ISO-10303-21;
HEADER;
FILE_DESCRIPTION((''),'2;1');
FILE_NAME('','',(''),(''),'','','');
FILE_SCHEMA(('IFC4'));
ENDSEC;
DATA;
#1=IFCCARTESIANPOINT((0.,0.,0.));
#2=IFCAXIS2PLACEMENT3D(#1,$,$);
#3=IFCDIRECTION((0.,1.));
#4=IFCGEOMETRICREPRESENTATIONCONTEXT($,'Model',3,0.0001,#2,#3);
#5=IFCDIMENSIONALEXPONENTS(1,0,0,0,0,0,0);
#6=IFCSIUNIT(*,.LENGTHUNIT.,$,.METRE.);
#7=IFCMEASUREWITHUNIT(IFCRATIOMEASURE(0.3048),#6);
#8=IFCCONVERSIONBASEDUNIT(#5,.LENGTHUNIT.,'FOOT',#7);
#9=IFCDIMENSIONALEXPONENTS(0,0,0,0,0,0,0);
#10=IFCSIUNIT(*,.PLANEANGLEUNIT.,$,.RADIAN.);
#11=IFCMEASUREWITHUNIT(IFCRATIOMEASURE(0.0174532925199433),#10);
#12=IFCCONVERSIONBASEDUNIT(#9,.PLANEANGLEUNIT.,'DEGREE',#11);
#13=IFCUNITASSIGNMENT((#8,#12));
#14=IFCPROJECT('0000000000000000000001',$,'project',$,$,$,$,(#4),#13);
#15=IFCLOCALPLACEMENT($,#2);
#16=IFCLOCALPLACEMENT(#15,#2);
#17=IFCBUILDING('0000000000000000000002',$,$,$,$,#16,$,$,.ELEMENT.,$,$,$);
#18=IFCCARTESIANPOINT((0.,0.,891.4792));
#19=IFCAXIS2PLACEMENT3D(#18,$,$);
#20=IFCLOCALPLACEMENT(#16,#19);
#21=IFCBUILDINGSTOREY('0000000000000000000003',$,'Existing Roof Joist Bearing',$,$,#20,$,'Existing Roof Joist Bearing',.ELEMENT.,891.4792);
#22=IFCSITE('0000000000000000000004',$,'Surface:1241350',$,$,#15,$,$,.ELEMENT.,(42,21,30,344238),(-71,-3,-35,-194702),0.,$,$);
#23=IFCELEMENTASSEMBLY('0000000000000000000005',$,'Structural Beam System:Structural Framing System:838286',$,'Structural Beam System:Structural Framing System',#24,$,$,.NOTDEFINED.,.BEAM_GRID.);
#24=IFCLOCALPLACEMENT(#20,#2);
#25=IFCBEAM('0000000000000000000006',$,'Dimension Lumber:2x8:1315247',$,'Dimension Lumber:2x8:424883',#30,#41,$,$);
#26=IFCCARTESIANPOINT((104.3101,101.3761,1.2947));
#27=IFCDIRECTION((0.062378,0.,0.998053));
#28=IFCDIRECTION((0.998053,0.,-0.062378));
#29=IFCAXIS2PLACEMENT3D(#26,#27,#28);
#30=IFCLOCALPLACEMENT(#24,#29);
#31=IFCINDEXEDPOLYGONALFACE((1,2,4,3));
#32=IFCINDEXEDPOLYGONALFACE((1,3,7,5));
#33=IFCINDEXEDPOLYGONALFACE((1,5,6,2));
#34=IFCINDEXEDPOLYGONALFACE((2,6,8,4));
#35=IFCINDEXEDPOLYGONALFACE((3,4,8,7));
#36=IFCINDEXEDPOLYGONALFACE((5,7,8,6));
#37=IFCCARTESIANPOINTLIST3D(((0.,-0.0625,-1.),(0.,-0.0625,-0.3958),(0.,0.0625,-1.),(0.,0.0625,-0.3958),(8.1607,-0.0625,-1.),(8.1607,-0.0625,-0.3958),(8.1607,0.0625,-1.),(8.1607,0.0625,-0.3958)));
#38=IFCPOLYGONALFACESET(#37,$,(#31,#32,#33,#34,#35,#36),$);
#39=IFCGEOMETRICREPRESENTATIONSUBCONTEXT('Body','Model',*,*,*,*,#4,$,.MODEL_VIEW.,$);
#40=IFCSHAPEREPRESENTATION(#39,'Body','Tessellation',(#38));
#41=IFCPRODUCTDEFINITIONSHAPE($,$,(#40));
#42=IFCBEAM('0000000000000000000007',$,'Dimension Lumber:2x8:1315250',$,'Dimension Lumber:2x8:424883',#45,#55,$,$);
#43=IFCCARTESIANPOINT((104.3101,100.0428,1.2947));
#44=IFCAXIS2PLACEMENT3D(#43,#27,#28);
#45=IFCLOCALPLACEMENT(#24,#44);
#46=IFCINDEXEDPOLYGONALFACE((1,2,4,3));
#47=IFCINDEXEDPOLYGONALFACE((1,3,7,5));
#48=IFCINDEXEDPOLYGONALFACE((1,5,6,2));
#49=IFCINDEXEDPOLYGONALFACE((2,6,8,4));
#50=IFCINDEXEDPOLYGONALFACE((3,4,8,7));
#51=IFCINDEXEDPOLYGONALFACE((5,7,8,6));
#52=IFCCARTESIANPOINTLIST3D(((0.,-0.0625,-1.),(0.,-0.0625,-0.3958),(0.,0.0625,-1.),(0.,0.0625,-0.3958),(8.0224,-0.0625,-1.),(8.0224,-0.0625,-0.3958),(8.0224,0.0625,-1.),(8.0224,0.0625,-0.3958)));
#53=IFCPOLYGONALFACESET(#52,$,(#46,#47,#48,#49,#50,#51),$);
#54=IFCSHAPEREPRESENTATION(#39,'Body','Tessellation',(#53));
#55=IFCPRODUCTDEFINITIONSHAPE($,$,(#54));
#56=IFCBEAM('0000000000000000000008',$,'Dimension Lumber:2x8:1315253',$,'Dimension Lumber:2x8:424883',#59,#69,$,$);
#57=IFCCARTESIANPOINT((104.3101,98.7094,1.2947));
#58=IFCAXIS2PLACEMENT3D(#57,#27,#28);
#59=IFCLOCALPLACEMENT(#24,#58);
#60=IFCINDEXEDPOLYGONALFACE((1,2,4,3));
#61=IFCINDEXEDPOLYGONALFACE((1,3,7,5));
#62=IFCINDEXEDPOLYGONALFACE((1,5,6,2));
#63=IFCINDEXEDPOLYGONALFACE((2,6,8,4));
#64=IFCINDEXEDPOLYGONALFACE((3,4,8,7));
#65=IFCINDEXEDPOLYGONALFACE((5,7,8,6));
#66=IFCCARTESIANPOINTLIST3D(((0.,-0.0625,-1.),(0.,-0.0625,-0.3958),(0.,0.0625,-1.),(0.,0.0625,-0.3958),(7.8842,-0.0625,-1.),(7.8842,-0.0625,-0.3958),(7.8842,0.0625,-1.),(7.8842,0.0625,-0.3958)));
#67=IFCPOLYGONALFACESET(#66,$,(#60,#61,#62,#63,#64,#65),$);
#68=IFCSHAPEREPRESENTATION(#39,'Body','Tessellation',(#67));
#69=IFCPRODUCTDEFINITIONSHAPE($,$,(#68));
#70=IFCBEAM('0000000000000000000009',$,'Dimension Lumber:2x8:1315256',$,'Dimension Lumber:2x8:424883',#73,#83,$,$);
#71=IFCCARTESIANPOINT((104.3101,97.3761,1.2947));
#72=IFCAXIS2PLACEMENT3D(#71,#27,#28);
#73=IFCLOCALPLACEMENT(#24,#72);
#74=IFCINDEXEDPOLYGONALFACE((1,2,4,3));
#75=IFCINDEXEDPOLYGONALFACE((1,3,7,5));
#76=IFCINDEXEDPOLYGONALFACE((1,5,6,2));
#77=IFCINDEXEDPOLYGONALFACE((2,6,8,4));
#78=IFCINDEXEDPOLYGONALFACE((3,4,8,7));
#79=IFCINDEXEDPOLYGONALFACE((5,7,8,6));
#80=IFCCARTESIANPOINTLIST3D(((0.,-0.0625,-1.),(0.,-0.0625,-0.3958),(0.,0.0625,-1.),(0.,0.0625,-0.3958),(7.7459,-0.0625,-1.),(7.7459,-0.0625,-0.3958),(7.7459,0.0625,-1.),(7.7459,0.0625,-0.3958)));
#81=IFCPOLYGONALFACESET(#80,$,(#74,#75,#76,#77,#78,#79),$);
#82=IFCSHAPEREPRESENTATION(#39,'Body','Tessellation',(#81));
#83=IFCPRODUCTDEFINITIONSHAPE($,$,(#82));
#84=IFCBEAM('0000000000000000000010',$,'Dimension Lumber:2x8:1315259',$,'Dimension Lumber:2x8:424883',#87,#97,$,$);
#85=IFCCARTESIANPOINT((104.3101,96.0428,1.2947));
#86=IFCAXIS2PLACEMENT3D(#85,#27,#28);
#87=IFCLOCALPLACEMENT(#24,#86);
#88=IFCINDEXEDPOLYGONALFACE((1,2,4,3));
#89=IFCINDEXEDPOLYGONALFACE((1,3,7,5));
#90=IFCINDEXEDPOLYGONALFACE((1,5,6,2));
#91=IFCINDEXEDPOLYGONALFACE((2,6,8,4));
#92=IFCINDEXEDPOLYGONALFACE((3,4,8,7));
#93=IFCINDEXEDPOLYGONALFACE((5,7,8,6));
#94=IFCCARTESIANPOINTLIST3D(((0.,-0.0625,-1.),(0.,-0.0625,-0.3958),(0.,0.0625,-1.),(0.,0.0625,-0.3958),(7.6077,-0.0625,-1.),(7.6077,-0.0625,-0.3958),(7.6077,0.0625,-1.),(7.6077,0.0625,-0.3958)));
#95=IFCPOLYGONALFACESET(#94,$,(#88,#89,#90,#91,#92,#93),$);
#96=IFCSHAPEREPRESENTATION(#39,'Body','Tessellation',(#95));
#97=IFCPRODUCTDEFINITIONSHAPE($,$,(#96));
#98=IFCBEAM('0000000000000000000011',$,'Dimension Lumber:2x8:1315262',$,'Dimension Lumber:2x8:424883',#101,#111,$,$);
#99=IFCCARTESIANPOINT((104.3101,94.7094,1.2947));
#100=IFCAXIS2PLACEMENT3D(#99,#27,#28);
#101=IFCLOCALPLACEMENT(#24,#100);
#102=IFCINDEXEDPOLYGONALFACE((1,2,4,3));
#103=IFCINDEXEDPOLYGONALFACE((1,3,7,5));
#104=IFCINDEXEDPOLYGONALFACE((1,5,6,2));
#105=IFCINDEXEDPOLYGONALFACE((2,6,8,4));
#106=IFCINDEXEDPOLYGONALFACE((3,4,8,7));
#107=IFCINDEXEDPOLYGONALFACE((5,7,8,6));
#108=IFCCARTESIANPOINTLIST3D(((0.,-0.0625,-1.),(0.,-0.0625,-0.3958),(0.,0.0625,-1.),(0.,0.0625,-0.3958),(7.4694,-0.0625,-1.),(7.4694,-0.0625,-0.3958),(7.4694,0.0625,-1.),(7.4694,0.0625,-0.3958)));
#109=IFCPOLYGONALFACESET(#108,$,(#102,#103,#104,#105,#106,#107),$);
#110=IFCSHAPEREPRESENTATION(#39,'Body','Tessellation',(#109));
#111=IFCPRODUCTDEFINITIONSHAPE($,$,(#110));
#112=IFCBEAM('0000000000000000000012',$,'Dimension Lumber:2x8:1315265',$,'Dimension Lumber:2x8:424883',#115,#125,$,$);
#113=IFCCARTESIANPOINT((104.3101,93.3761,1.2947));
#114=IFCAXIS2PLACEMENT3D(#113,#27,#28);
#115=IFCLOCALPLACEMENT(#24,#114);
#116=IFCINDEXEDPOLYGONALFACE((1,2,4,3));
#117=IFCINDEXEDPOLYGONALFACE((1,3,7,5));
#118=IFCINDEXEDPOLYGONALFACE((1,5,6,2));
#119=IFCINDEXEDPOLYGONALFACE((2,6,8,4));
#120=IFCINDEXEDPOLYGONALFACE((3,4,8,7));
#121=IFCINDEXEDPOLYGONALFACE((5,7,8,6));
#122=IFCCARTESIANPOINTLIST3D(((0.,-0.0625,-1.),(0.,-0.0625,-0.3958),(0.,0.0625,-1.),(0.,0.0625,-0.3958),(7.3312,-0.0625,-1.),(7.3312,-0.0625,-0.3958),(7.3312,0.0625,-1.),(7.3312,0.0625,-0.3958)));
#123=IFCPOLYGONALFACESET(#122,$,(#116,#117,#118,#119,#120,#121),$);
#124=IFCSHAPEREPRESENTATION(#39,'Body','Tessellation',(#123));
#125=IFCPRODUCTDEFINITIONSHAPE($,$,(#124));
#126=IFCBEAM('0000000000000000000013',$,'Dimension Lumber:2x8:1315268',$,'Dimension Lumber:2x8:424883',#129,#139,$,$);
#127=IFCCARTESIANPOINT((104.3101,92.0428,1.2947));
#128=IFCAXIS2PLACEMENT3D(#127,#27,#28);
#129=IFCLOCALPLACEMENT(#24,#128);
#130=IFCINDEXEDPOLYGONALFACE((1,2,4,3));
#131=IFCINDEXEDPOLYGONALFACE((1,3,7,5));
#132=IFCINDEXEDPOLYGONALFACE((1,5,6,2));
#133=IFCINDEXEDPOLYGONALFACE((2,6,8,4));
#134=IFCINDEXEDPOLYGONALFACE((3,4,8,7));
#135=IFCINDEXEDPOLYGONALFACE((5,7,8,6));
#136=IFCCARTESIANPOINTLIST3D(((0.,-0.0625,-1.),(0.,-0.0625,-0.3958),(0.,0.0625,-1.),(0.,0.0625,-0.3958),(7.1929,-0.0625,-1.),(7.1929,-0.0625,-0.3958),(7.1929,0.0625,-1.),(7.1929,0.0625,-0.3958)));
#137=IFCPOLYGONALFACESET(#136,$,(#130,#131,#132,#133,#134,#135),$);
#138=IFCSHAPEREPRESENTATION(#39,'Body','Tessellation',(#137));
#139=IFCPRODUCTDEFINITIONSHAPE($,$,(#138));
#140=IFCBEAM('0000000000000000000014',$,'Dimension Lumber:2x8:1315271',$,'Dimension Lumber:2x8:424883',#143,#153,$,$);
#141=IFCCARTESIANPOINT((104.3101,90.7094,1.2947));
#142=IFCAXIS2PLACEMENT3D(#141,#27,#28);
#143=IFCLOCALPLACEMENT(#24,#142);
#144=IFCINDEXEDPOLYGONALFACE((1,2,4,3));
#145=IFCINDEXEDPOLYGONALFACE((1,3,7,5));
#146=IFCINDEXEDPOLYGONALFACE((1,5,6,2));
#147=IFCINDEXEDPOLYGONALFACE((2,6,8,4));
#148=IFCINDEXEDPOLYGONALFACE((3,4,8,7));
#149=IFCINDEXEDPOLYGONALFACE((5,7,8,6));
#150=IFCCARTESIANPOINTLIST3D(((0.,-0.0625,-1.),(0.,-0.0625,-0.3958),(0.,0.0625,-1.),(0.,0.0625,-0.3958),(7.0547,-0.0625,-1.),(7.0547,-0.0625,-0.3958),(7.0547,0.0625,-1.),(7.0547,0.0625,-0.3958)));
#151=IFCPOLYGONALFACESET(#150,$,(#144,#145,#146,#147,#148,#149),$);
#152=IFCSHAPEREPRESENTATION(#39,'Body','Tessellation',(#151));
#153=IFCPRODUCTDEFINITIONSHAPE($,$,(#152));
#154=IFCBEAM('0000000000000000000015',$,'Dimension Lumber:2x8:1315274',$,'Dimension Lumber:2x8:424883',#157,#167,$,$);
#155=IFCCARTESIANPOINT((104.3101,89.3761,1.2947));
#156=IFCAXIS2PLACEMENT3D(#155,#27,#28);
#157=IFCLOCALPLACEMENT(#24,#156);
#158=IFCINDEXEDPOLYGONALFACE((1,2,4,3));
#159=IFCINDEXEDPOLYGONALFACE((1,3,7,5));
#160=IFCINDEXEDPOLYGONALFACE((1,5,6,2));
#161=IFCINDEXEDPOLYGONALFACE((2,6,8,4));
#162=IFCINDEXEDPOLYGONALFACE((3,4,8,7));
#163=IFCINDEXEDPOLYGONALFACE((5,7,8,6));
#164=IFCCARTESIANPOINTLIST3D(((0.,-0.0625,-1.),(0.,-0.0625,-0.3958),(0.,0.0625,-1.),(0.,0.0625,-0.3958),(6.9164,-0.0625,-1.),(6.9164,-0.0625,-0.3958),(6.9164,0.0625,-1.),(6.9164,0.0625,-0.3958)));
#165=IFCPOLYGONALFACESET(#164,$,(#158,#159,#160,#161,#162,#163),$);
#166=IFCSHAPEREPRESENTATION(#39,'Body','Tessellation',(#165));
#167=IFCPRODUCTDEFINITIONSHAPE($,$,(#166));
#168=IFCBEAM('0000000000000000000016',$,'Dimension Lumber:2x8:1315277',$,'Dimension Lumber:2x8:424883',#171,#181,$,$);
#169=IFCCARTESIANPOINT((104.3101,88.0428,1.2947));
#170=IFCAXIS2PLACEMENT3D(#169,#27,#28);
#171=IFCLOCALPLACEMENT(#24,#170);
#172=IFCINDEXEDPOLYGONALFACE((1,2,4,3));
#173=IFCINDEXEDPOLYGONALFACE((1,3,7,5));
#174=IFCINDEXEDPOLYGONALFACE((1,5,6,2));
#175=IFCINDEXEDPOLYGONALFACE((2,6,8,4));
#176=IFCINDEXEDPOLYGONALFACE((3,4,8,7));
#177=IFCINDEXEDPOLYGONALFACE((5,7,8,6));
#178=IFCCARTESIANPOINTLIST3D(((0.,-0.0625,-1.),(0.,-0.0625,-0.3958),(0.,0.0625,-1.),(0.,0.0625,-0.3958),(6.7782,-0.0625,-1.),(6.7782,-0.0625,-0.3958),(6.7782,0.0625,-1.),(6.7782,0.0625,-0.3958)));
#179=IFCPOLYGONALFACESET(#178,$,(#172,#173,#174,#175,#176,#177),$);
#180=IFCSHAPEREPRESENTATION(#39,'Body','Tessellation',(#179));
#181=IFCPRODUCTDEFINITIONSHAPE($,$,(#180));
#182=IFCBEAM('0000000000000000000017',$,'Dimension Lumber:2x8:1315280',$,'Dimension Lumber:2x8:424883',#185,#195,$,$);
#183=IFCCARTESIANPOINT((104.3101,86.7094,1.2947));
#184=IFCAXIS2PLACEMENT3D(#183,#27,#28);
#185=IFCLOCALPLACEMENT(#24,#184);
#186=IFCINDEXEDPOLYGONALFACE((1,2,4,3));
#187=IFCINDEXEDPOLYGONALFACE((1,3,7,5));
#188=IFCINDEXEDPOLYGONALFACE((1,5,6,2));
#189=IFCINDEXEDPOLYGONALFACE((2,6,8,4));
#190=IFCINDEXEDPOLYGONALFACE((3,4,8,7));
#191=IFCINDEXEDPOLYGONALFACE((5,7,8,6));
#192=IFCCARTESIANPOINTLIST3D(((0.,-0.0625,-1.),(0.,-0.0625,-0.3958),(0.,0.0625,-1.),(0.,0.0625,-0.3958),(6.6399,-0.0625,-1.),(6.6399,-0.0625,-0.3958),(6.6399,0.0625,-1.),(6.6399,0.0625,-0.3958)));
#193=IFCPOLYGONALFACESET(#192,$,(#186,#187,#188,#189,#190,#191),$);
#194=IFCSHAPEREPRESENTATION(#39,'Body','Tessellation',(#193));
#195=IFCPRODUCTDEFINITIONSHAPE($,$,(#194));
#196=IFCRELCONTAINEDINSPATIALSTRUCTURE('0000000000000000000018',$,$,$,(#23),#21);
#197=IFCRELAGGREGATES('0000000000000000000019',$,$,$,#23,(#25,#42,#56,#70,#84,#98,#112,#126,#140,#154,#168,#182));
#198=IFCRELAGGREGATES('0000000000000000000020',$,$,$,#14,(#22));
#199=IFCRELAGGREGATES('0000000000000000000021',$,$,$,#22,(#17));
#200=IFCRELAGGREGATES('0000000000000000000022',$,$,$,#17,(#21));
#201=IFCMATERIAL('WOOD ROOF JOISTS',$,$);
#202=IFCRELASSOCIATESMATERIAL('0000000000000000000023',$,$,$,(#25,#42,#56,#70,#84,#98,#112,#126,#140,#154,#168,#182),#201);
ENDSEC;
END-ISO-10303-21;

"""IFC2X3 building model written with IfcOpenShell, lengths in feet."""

from ifc_helpers import new_model, entity, si_unit, converted_unit, direction, frame, frame_2d, origin, place, context, subcontext, project, spatial, rectangle, extrude, material, element, aggregate, save


model = new_model("IFC2X3")

# Units and contexts
model_context = context("Model", 3, precision=0.0001, world=origin(), true_north=direction((0.0, 1.0)))
body_context = subcontext(model_context, "Body", "Model", "MODEL_VIEW")
ifc_project = project(units=[converted_unit("LENGTHUNIT", "FOOT", entity("IfcRatioMeasure", 0.3048), si_unit("LENGTHUNIT", "METRE"), dimensions=[1, 0, 0, 0, 0, 0, 0]), converted_unit("PLANEANGLEUNIT", "DEGREE", entity("IfcRatioMeasure", 0.0174532925199433), si_unit("PLANEANGLEUNIT", "RADIAN"), dimensions=[0, 0, 0, 0, 0, 0, 0])], contexts=[model_context])

# Site, building, storey
site_placement = place(None, origin())
site = spatial("IfcSite", under=ifc_project, at=site_placement, Name="Surface:1241350", CompositionType="ELEMENT", RefLatitude=(42, 21, 30, 344238), RefLongitude=(-71, -3, -35, -194702), RefElevation=0.0)
building_placement = place(site_placement, origin())
building = spatial("IfcBuilding", under=site, at=building_placement, CompositionType="ELEMENT")
storey_placement = place(building_placement, frame((0.0, 0.0, 891.4792)))
storey = spatial("IfcBuildingStorey", under=building, at=storey_placement, Name="Existing Roof Joist Bearing", LongName="Existing Roof Joist Bearing", CompositionType="ELEMENT", Elevation=891.4792)

# Element assembly, beams
assembly_1_placement = place(storey_placement, origin())
assembly_1 = element("IfcElementAssembly", 1, at=assembly_1_placement, inside=storey, Name="Structural Beam System:Structural Framing System:838286", ObjectType="Structural Beam System:Structural Framing System", AssemblyPlace="NOTDEFINED", PredefinedType="BEAM_GRID")
ifc_material_1 = material(Name="WOOD ROOF JOISTS")
beam_1_placement = place(assembly_1_placement, frame((104.3101, 101.3761, 1.2947), z_axis=(0.062378, 0.0, 0.998053), x_axis=(0.998053, 0.0, -0.062378)))
beam_1 = element("IfcBeam", 2, at=beam_1_placement, material=ifc_material_1, Name="Dimension Lumber:2x8:1315247", ObjectType="Dimension Lumber:2x8:424883", context=body_context, shape_type="SweptSolid", body=[
    extrude(rectangle(XDim=0.6042, YDim=0.125, at=frame_2d((0.0, 0.0), x_axis=(1.0, 0.0))), frame((0.0, 0.0, -0.6979), z_axis=(1.0, 0.0, 0.0), x_axis=(0.0, 0.0, -1.0)), (0.0, 0.0, 1.0), 8.1607),
])
beam_2_placement = place(assembly_1_placement, frame((104.3101, 100.0428, 1.2947), z_axis=(0.062378, 0.0, 0.998053), x_axis=(0.998053, 0.0, -0.062378)))
beam_2 = element("IfcBeam", 3, at=beam_2_placement, material=ifc_material_1, Name="Dimension Lumber:2x8:1315250", ObjectType="Dimension Lumber:2x8:424883", context=body_context, shape_type="SweptSolid", body=[
    extrude(rectangle(XDim=0.6042, YDim=0.125, at=frame_2d((0.0, 0.0), x_axis=(1.0, 0.0))), frame((0.0, 0.0, -0.6979), z_axis=(1.0, 0.0, 0.0), x_axis=(0.0, 0.0, -1.0)), (0.0, 0.0, 1.0), 8.0224),
])
beam_3_placement = place(assembly_1_placement, frame((104.3101, 98.7094, 1.2947), z_axis=(0.062378, 0.0, 0.998053), x_axis=(0.998053, 0.0, -0.062378)))
beam_3 = element("IfcBeam", 4, at=beam_3_placement, material=ifc_material_1, Name="Dimension Lumber:2x8:1315253", ObjectType="Dimension Lumber:2x8:424883", context=body_context, shape_type="SweptSolid", body=[
    extrude(rectangle(XDim=0.6042, YDim=0.125, at=frame_2d((0.0, 0.0), x_axis=(1.0, 0.0))), frame((0.0, 0.0, -0.6979), z_axis=(1.0, 0.0, 0.0), x_axis=(0.0, 0.0, -1.0)), (0.0, 0.0, 1.0), 7.8842),
])
beam_4_placement = place(assembly_1_placement, frame((104.3101, 97.3761, 1.2947), z_axis=(0.062378, 0.0, 0.998053), x_axis=(0.998053, 0.0, -0.062378)))
beam_4 = element("IfcBeam", 5, at=beam_4_placement, material=ifc_material_1, Name="Dimension Lumber:2x8:1315256", ObjectType="Dimension Lumber:2x8:424883", context=body_context, shape_type="SweptSolid", body=[
    extrude(rectangle(XDim=0.6042, YDim=0.125, at=frame_2d((0.0, 0.0), x_axis=(1.0, 0.0))), frame((0.0, 0.0, -0.6979), z_axis=(1.0, 0.0, 0.0), x_axis=(0.0, 0.0, -1.0)), (0.0, 0.0, 1.0), 7.7459),
])
beam_5_placement = place(assembly_1_placement, frame((104.3101, 96.0428, 1.2947), z_axis=(0.062378, 0.0, 0.998053), x_axis=(0.998053, 0.0, -0.062378)))
beam_5 = element("IfcBeam", 6, at=beam_5_placement, material=ifc_material_1, Name="Dimension Lumber:2x8:1315259", ObjectType="Dimension Lumber:2x8:424883", context=body_context, shape_type="SweptSolid", body=[
    extrude(rectangle(XDim=0.6042, YDim=0.125, at=frame_2d((0.0, 0.0), x_axis=(1.0, 0.0))), frame((0.0, 0.0, -0.6979), z_axis=(1.0, 0.0, 0.0), x_axis=(0.0, 0.0, -1.0)), (0.0, 0.0, 1.0), 7.6077),
])
beam_6_placement = place(assembly_1_placement, frame((104.3101, 94.7094, 1.2947), z_axis=(0.062378, 0.0, 0.998053), x_axis=(0.998053, 0.0, -0.062378)))
beam_6 = element("IfcBeam", 7, at=beam_6_placement, material=ifc_material_1, Name="Dimension Lumber:2x8:1315262", ObjectType="Dimension Lumber:2x8:424883", context=body_context, shape_type="SweptSolid", body=[
    extrude(rectangle(XDim=0.6042, YDim=0.125, at=frame_2d((0.0, 0.0), x_axis=(1.0, 0.0))), frame((0.0, 0.0, -0.6979), z_axis=(1.0, 0.0, 0.0), x_axis=(0.0, 0.0, -1.0)), (0.0, 0.0, 1.0), 7.4694),
])
beam_7_placement = place(assembly_1_placement, frame((104.3101, 93.3761, 1.2947), z_axis=(0.062378, 0.0, 0.998053), x_axis=(0.998053, 0.0, -0.062378)))
beam_7 = element("IfcBeam", 8, at=beam_7_placement, material=ifc_material_1, Name="Dimension Lumber:2x8:1315265", ObjectType="Dimension Lumber:2x8:424883", context=body_context, shape_type="SweptSolid", body=[
    extrude(rectangle(XDim=0.6042, YDim=0.125, at=frame_2d((0.0, 0.0), x_axis=(1.0, 0.0))), frame((0.0, 0.0, -0.6979), z_axis=(1.0, 0.0, 0.0), x_axis=(0.0, 0.0, -1.0)), (0.0, 0.0, 1.0), 7.3312),
])
beam_8_placement = place(assembly_1_placement, frame((104.3101, 92.0428, 1.2947), z_axis=(0.062378, 0.0, 0.998053), x_axis=(0.998053, 0.0, -0.062378)))
beam_8 = element("IfcBeam", 9, at=beam_8_placement, material=ifc_material_1, Name="Dimension Lumber:2x8:1315268", ObjectType="Dimension Lumber:2x8:424883", context=body_context, shape_type="SweptSolid", body=[
    extrude(rectangle(XDim=0.6042, YDim=0.125, at=frame_2d((0.0, 0.0), x_axis=(1.0, 0.0))), frame((0.0, 0.0, -0.6979), z_axis=(1.0, 0.0, 0.0), x_axis=(0.0, 0.0, -1.0)), (0.0, 0.0, 1.0), 7.1929),
])
beam_9_placement = place(assembly_1_placement, frame((104.3101, 90.7094, 1.2947), z_axis=(0.062378, 0.0, 0.998053), x_axis=(0.998053, 0.0, -0.062378)))
beam_9 = element("IfcBeam", 10, at=beam_9_placement, material=ifc_material_1, Name="Dimension Lumber:2x8:1315271", ObjectType="Dimension Lumber:2x8:424883", context=body_context, shape_type="SweptSolid", body=[
    extrude(rectangle(XDim=0.6042, YDim=0.125, at=frame_2d((0.0, 0.0), x_axis=(1.0, 0.0))), frame((0.0, 0.0, -0.6979), z_axis=(1.0, 0.0, 0.0), x_axis=(0.0, 0.0, -1.0)), (0.0, 0.0, 1.0), 7.0547),
])
beam_10_placement = place(assembly_1_placement, frame((104.3101, 89.3761, 1.2947), z_axis=(0.062378, 0.0, 0.998053), x_axis=(0.998053, 0.0, -0.062378)))
beam_10 = element("IfcBeam", 11, at=beam_10_placement, material=ifc_material_1, Name="Dimension Lumber:2x8:1315274", ObjectType="Dimension Lumber:2x8:424883", context=body_context, shape_type="SweptSolid", body=[
    extrude(rectangle(XDim=0.6042, YDim=0.125, at=frame_2d((0.0, 0.0), x_axis=(1.0, 0.0))), frame((0.0, 0.0, -0.6979), z_axis=(1.0, 0.0, 0.0), x_axis=(0.0, 0.0, -1.0)), (0.0, 0.0, 1.0), 6.9164),
])
beam_11_placement = place(assembly_1_placement, frame((104.3101, 88.0428, 1.2947), z_axis=(0.062378, 0.0, 0.998053), x_axis=(0.998053, 0.0, -0.062378)))
beam_11 = element("IfcBeam", 12, at=beam_11_placement, material=ifc_material_1, Name="Dimension Lumber:2x8:1315277", ObjectType="Dimension Lumber:2x8:424883", context=body_context, shape_type="SweptSolid", body=[
    extrude(rectangle(XDim=0.6042, YDim=0.125, at=frame_2d((0.0, 0.0), x_axis=(1.0, 0.0))), frame((0.0, 0.0, -0.6979), z_axis=(1.0, 0.0, 0.0), x_axis=(0.0, 0.0, -1.0)), (0.0, 0.0, 1.0), 6.7782),
])
beam_12_placement = place(assembly_1_placement, frame((104.3101, 86.7094, 1.2947), z_axis=(0.062378, 0.0, 0.998053), x_axis=(0.998053, 0.0, -0.062378)))
beam_12 = element("IfcBeam", 13, at=beam_12_placement, material=ifc_material_1, Name="Dimension Lumber:2x8:1315280", ObjectType="Dimension Lumber:2x8:424883", context=body_context, shape_type="SweptSolid", body=[
    extrude(rectangle(XDim=0.6042, YDim=0.125, at=frame_2d((0.0, 0.0), x_axis=(1.0, 0.0))), frame((0.0, 0.0, -0.6979), z_axis=(1.0, 0.0, 0.0), x_axis=(0.0, 0.0, -1.0)), (0.0, 0.0, 1.0), 6.6399),
])
aggregate(assembly_1, [beam_1, beam_2, beam_3, beam_4, beam_5, beam_6, beam_7, beam_8, beam_9, beam_10, beam_11, beam_12])

save(model, "model.ifc")
